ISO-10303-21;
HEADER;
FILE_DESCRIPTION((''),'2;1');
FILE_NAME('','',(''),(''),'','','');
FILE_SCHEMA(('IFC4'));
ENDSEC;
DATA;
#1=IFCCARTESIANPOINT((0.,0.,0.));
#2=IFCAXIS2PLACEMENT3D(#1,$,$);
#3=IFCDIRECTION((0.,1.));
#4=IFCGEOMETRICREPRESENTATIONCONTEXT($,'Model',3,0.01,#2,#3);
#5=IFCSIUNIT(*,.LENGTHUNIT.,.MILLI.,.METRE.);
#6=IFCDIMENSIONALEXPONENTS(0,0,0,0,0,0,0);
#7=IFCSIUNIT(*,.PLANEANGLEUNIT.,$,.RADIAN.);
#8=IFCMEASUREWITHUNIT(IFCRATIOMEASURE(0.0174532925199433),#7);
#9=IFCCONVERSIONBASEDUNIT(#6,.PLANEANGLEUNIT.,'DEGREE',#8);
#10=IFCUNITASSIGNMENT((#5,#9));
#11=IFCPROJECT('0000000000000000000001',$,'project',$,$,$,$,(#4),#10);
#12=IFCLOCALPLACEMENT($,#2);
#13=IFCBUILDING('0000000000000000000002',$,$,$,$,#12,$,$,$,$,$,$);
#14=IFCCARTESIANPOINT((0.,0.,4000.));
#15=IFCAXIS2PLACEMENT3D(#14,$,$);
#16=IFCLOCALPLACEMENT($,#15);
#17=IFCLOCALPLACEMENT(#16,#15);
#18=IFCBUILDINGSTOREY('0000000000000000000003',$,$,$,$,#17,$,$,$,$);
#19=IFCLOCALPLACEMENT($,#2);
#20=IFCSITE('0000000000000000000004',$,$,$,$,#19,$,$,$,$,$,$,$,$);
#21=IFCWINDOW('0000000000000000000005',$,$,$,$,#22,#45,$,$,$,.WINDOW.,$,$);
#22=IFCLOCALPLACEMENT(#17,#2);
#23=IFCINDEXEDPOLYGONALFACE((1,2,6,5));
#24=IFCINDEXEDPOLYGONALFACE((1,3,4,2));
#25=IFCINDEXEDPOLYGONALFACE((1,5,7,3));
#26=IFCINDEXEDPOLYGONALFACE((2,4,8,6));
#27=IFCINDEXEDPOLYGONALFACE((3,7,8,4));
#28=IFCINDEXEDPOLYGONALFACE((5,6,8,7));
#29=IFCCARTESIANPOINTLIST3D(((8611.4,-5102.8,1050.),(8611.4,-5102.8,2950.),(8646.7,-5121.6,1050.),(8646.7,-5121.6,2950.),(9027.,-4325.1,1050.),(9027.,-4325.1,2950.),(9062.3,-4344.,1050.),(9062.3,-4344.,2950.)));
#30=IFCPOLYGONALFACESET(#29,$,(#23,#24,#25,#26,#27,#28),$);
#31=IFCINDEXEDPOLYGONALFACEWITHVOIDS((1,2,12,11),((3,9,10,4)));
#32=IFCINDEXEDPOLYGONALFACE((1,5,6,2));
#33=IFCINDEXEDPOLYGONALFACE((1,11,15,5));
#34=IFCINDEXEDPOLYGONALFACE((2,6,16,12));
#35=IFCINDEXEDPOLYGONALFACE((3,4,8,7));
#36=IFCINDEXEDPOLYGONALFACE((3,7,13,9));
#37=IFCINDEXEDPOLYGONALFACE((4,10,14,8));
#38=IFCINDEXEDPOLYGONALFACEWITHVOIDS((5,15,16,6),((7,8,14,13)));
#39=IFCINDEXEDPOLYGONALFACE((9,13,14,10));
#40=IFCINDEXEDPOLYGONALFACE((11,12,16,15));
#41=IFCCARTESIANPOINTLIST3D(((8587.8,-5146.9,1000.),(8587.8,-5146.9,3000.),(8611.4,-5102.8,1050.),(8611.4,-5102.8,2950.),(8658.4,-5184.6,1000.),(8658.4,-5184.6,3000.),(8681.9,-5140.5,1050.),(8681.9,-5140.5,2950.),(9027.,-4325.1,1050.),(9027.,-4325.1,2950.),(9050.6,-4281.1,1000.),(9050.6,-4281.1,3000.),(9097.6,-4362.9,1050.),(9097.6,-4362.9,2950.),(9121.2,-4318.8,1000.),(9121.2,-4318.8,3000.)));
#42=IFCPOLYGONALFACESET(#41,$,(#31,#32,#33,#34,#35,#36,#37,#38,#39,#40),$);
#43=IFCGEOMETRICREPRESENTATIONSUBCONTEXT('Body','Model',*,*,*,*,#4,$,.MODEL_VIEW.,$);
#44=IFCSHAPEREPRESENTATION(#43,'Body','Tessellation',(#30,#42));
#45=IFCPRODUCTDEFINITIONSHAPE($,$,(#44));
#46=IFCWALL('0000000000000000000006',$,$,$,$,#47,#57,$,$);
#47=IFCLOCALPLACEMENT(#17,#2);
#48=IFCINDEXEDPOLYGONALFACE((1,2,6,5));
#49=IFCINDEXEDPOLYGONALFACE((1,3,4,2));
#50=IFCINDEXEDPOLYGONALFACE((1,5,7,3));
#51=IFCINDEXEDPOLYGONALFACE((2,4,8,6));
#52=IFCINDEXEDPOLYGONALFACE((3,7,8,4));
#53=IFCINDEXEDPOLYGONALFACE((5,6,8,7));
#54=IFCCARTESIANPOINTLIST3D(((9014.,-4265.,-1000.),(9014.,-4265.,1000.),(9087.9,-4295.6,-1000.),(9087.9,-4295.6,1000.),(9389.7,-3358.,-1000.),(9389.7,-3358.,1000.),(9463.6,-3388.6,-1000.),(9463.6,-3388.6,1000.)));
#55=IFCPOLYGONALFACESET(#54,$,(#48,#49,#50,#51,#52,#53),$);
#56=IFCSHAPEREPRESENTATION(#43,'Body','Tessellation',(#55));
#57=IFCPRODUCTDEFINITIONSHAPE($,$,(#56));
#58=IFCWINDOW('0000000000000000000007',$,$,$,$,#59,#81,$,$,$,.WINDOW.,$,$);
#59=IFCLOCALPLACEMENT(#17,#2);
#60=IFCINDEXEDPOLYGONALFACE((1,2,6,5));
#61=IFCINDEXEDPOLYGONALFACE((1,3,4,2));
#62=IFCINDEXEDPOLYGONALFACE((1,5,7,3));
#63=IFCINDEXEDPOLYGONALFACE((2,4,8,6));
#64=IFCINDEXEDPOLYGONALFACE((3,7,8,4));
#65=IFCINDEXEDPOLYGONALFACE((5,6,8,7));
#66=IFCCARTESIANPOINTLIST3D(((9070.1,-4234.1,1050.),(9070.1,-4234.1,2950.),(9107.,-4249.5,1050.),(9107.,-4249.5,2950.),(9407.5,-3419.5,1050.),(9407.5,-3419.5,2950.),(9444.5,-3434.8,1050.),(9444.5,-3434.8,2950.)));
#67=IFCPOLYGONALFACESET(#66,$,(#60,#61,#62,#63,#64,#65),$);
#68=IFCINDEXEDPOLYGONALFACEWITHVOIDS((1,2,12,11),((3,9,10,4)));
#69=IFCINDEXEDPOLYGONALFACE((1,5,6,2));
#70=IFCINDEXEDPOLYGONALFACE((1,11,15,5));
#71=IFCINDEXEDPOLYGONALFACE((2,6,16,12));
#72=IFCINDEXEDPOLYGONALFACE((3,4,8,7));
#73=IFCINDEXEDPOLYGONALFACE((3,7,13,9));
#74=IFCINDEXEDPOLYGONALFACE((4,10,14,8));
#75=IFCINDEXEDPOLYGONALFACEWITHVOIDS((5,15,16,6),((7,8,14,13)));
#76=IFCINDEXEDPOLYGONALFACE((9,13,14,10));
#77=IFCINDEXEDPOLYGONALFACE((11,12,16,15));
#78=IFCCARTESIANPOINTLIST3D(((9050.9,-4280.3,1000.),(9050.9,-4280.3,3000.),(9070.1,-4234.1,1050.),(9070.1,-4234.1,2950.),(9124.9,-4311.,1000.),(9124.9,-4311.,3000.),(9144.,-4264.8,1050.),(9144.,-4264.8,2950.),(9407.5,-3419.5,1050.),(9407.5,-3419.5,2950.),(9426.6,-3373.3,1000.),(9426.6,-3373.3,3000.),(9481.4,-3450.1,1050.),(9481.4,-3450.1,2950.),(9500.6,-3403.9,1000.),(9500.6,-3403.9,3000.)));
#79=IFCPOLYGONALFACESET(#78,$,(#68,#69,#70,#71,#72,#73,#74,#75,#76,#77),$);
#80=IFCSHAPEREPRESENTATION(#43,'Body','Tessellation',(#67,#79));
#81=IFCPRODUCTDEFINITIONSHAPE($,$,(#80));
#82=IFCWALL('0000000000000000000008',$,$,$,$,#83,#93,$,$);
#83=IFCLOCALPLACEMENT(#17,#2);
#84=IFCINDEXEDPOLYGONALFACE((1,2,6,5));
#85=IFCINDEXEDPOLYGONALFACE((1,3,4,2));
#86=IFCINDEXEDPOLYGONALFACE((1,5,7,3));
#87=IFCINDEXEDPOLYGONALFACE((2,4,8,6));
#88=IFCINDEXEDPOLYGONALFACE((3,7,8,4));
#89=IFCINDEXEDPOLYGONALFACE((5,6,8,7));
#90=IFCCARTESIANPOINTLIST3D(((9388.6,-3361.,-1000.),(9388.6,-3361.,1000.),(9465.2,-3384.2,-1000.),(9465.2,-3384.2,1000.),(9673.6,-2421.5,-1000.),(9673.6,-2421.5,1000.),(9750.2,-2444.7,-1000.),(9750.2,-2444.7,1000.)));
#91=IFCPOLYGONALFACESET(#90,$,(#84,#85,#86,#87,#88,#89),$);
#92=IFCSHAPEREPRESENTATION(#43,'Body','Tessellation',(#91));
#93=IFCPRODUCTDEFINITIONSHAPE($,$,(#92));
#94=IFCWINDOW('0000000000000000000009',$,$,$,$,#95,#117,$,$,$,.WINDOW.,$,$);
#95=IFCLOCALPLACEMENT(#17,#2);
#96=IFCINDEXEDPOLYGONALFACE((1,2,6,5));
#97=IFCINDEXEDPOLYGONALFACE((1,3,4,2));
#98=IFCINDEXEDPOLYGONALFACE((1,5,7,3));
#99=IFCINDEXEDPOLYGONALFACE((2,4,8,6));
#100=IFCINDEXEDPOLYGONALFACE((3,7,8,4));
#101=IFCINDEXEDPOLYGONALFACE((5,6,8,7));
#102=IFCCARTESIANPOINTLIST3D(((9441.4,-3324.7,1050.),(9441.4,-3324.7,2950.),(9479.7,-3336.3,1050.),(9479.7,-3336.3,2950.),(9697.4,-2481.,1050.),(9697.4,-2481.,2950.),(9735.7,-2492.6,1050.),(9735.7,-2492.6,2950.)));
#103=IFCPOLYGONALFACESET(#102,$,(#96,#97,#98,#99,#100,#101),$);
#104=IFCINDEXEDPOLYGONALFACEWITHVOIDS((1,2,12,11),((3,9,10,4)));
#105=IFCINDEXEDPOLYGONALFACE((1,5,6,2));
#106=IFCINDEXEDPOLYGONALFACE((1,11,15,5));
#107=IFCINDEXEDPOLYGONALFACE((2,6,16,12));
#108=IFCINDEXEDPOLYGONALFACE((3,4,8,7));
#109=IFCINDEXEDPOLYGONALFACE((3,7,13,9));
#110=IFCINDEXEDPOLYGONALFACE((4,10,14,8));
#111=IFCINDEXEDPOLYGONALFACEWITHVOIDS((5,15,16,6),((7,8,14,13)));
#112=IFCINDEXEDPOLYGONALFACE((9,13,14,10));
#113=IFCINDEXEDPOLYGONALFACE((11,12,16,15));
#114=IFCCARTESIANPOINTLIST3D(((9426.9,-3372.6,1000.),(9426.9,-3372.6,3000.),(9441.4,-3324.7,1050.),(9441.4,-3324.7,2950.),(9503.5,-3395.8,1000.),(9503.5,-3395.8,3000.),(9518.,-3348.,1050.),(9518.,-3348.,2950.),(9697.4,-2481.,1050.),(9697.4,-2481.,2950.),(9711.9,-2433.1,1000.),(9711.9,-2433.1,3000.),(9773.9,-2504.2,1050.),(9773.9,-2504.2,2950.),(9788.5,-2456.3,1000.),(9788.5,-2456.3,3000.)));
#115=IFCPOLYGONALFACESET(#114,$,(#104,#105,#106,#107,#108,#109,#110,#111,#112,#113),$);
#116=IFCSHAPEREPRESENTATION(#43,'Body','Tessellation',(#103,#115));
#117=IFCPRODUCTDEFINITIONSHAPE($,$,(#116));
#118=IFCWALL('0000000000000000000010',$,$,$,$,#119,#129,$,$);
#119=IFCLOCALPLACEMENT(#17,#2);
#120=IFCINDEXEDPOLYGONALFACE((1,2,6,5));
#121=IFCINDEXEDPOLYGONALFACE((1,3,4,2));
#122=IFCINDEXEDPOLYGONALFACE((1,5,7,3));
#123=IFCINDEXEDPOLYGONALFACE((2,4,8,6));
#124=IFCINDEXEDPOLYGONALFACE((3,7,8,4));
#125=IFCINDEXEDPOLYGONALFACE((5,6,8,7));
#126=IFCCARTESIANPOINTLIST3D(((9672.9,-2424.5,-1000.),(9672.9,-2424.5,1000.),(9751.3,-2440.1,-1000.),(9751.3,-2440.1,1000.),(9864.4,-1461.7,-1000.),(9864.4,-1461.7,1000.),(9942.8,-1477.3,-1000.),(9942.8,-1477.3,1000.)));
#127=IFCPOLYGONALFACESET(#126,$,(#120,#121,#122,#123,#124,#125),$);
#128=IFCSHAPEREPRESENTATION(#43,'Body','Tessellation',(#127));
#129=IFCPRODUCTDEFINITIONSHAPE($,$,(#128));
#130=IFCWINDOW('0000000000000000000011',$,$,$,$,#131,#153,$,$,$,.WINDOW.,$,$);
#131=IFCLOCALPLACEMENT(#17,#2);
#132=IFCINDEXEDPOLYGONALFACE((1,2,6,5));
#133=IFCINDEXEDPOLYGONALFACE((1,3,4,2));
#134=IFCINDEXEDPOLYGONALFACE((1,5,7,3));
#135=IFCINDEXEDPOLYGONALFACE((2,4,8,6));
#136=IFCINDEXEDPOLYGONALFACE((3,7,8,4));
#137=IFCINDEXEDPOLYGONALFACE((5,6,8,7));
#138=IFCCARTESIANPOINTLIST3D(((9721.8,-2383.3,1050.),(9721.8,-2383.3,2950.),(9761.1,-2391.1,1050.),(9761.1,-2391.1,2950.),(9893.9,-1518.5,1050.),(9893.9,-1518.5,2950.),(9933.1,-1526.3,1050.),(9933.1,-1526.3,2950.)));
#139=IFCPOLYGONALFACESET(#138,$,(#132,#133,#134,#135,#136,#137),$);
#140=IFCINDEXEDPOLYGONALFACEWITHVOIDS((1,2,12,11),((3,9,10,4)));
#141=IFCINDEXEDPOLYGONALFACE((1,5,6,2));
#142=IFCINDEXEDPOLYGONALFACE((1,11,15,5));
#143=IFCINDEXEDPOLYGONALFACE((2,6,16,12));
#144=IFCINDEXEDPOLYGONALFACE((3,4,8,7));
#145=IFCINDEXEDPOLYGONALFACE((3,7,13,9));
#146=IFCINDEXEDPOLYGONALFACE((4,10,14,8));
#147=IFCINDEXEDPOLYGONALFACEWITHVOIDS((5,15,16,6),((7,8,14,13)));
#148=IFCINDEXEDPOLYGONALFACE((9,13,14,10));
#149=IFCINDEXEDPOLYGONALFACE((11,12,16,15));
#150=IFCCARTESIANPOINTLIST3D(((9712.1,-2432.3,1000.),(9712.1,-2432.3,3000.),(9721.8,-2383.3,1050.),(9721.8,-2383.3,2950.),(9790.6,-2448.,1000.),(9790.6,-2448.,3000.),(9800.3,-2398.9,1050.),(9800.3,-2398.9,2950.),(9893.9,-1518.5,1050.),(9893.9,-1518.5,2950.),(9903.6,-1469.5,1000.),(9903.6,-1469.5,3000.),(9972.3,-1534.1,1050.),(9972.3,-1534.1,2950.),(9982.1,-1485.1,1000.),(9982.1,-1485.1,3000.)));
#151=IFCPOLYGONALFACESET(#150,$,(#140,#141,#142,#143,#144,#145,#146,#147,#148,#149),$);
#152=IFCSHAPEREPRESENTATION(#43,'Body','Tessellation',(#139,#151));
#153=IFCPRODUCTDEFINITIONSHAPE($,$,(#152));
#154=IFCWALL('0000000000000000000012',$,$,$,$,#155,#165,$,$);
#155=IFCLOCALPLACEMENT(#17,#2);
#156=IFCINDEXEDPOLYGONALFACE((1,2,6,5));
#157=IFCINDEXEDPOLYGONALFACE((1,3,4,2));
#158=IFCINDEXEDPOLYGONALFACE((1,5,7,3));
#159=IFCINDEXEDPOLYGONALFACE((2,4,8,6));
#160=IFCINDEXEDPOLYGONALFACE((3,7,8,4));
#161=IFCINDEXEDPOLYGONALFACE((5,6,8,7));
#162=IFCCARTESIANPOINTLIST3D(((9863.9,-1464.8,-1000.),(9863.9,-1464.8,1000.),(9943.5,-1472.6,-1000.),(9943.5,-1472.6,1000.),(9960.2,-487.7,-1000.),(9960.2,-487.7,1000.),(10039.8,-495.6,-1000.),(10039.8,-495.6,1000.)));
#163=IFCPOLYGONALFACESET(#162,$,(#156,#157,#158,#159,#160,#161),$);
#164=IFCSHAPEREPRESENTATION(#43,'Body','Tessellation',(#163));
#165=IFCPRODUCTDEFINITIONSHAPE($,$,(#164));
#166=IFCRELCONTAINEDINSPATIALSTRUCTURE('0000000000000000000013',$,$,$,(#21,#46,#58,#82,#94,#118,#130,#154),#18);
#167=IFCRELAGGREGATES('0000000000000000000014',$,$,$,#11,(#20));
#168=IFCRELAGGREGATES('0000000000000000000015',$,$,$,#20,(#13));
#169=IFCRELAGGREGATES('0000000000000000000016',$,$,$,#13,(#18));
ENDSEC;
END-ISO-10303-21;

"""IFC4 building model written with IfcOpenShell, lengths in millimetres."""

from ifc_helpers import new_model, entity, si_unit, converted_unit, direction, frame, origin, origin_2d, place, context, subcontext, project, spatial, rectangle, extrude, element, save


model = new_model("IFC4")

# Units and contexts
model_context = context("Model", 3, precision=0.01, world=origin(), true_north=direction((0.0, 1.0)))
body_context = subcontext(model_context, "Body", "Model", "MODEL_VIEW")
ifc_project = project(units=[si_unit("LENGTHUNIT", "METRE", prefix="MILLI"), converted_unit("PLANEANGLEUNIT", "DEGREE", entity("IfcRatioMeasure", 0.0174532925199433), si_unit("PLANEANGLEUNIT", "RADIAN"), dimensions=[0, 0, 0, 0, 0, 0, 0])], contexts=[model_context])

# Site, building, storey
site_placement = place(None, origin())
site = spatial("IfcSite", under=ifc_project, at=site_placement)
building_placement = place(None, origin())
building = spatial("IfcBuilding", under=site, at=building_placement)
placement = place(None, frame((0.0, 0.0, 4000.0)))
storey_placement = place(placement, frame((0.0, 0.0, 4000.0)))
storey = spatial("IfcBuildingStorey", under=building, at=storey_placement)

# Shared definitions
cartesian_point_1 = entity("IfcCartesianPoint", [-440.9, -950.0])
shared_polyline = entity("IfcPolyline", [cartesian_point_1, entity("IfcCartesianPoint", [-440.9, 950.0]), entity("IfcCartesianPoint", [-440.9, 950.0]), entity("IfcCartesianPoint", [440.9, 950.0]), entity("IfcCartesianPoint", [440.9, 950.0]), entity("IfcCartesianPoint", [440.9, -950.0]), entity("IfcCartesianPoint", [440.9, -950.0]), entity("IfcCartesianPoint", [-440.9, -950.0]), cartesian_point_1])

# Window
window_1_placement = place(storey_placement, frame((8819.2, -4714.0, 2000.0), z_axis=(0.0, 0.0, 1.0), x_axis=(4713.965487, 8819.213649, 0.0)))
cartesian_point_2 = entity("IfcCartesianPoint", [-490.9, -1000.0])
element("IfcWindow", 1, at=window_1_placement, inside=storey, PredefinedType="WINDOW", context=body_context, shape_type="SweptSolid", body=[
    entity("IfcExtrudedAreaSolid", entity("IfcArbitraryClosedProfileDef", "AREA", None, shared_polyline), entity("IfcAxis2Placement3D", entity("IfcCartesianPoint", [0.0, 0.0, 0.0]), entity("IfcDirection", [0.0, -1.0, 0.0]), entity("IfcDirection", [1.0, 0.0, 0.0])), entity("IfcDirection", [0.0, 0.0, 1.0]), 40.0),
    entity("IfcExtrudedAreaSolid", entity("IfcArbitraryProfileDefWithVoids", "AREA", None, entity("IfcPolyline", [cartesian_point_2, entity("IfcCartesianPoint", [-490.9, 1000.0]), entity("IfcCartesianPoint", [-490.9, 1000.0]), entity("IfcCartesianPoint", [490.9, 1000.0]), entity("IfcCartesianPoint", [490.9, 1000.0]), entity("IfcCartesianPoint", [490.9, -1000.0]), entity("IfcCartesianPoint", [490.9, -1000.0]), entity("IfcCartesianPoint", [-490.9, -1000.0]), cartesian_point_2]), [shared_polyline]), entity("IfcAxis2Placement3D", entity("IfcCartesianPoint", [0.0, 0.0, 0.0]), entity("IfcDirection", [0.0, -1.0, 0.0]), entity("IfcDirection", [1.0, 0.0, 0.0])), entity("IfcDirection", [0.0, 0.0, 1.0]), 80.0),
])

# Wall
wall_1_placement = place(storey_placement, frame((9238.8, -3826.8, -1000.0), z_axis=(0.0, 0.0, 1.0), x_axis=(3826.834186, 9238.795382, 0.0)))
element("IfcWall", 2, at=wall_1_placement, inside=storey, context=body_context, shape_type="SweptSolid", body=[
    extrude(rectangle(XDim=981.7, YDim=80.0, at=origin_2d()), origin(), (0.0, 0.0, 1.0), 2000.0),
])

# Window
window_2_placement = place(storey_placement, frame((9238.8, -3826.8, 2000.0), z_axis=(0.0, 0.0, 1.0), x_axis=(3826.834186, 9238.795382, 0.0)))
cartesian_point_3 = entity("IfcCartesianPoint", [-490.9, -1000.0])
element("IfcWindow", 3, at=window_2_placement, inside=storey, PredefinedType="WINDOW", context=body_context, shape_type="SweptSolid", body=[
    entity("IfcExtrudedAreaSolid", entity("IfcArbitraryClosedProfileDef", "AREA", None, shared_polyline), entity("IfcAxis2Placement3D", entity("IfcCartesianPoint", [0.0, 0.0, 0.0]), entity("IfcDirection", [0.0, -1.0, 0.0]), entity("IfcDirection", [1.0, 0.0, 0.0])), entity("IfcDirection", [0.0, 0.0, 1.0]), 40.0),
    entity("IfcExtrudedAreaSolid", entity("IfcArbitraryProfileDefWithVoids", "AREA", None, entity("IfcPolyline", [cartesian_point_3, entity("IfcCartesianPoint", [-490.9, 1000.0]), entity("IfcCartesianPoint", [-490.9, 1000.0]), entity("IfcCartesianPoint", [490.9, 1000.0]), entity("IfcCartesianPoint", [490.9, 1000.0]), entity("IfcCartesianPoint", [490.9, -1000.0]), entity("IfcCartesianPoint", [490.9, -1000.0]), entity("IfcCartesianPoint", [-490.9, -1000.0]), cartesian_point_3]), [shared_polyline]), entity("IfcAxis2Placement3D", entity("IfcCartesianPoint", [0.0, 0.0, 0.0]), entity("IfcDirection", [0.0, -1.0, 0.0]), entity("IfcDirection", [1.0, 0.0, 0.0])), entity("IfcDirection", [0.0, 0.0, 1.0]), 80.0),
])

# Wall
wall_2_placement = place(storey_placement, frame((9569.4, -2902.8, -1000.0), z_axis=(0.0, 0.0, 1.0), x_axis=(2902.848529, 9569.402825, 0.0)))
element("IfcWall", 4, at=wall_2_placement, inside=storey, context=body_context, shape_type="SweptSolid", body=[
    extrude(rectangle(XDim=981.7, YDim=80.0, at=origin_2d()), origin(), (0.0, 0.0, 1.0), 2000.0),
])

# Window
window_3_placement = place(storey_placement, frame((9569.4, -2902.8, 2000.0), z_axis=(0.0, 0.0, 1.0), x_axis=(2902.848529, 9569.402825, 0.0)))
cartesian_point_4 = entity("IfcCartesianPoint", [-490.9, -1000.0])
element("IfcWindow", 5, at=window_3_placement, inside=storey, PredefinedType="WINDOW", context=body_context, shape_type="SweptSolid", body=[
    entity("IfcExtrudedAreaSolid", entity("IfcArbitraryClosedProfileDef", "AREA", None, shared_polyline), entity("IfcAxis2Placement3D", entity("IfcCartesianPoint", [0.0, 0.0, 0.0]), entity("IfcDirection", [0.0, -1.0, 0.0]), entity("IfcDirection", [1.0, 0.0, 0.0])), entity("IfcDirection", [0.0, 0.0, 1.0]), 40.0),
    entity("IfcExtrudedAreaSolid", entity("IfcArbitraryProfileDefWithVoids", "AREA", None, entity("IfcPolyline", [cartesian_point_4, entity("IfcCartesianPoint", [-490.9, 1000.0]), entity("IfcCartesianPoint", [-490.9, 1000.0]), entity("IfcCartesianPoint", [490.9, 1000.0]), entity("IfcCartesianPoint", [490.9, 1000.0]), entity("IfcCartesianPoint", [490.9, -1000.0]), entity("IfcCartesianPoint", [490.9, -1000.0]), entity("IfcCartesianPoint", [-490.9, -1000.0]), cartesian_point_4]), [shared_polyline]), entity("IfcAxis2Placement3D", entity("IfcCartesianPoint", [0.0, 0.0, 0.0]), entity("IfcDirection", [0.0, -1.0, 0.0]), entity("IfcDirection", [1.0, 0.0, 0.0])), entity("IfcDirection", [0.0, 0.0, 1.0]), 80.0),
])

# Wall
wall_3_placement = place(storey_placement, frame((9807.9, -1950.9, -1000.0), z_axis=(0.0, 0.0, 1.0), x_axis=(1950.90229, 9807.852989, 0.0)))
element("IfcWall", 6, at=wall_3_placement, inside=storey, context=body_context, shape_type="SweptSolid", body=[
    extrude(rectangle(XDim=981.7, YDim=80.0, at=origin_2d()), origin(), (0.0, 0.0, 1.0), 2000.0),
])

# Window
window_4_placement = place(storey_placement, frame((9807.9, -1950.9, 2000.0), z_axis=(0.0, 0.0, 1.0), x_axis=(1950.90229, 9807.852989, 0.0)))
cartesian_point_5 = entity("IfcCartesianPoint", [-490.9, -1000.0])
element("IfcWindow", 7, at=window_4_placement, inside=storey, PredefinedType="WINDOW", context=body_context, shape_type="SweptSolid", body=[
    entity("IfcExtrudedAreaSolid", entity("IfcArbitraryClosedProfileDef", "AREA", None, shared_polyline), entity("IfcAxis2Placement3D", entity("IfcCartesianPoint", [0.0, 0.0, 0.0]), entity("IfcDirection", [0.0, -1.0, 0.0]), entity("IfcDirection", [1.0, 0.0, 0.0])), entity("IfcDirection", [0.0, 0.0, 1.0]), 40.0),
    entity("IfcExtrudedAreaSolid", entity("IfcArbitraryProfileDefWithVoids", "AREA", None, entity("IfcPolyline", [cartesian_point_5, entity("IfcCartesianPoint", [-490.9, 1000.0]), entity("IfcCartesianPoint", [-490.9, 1000.0]), entity("IfcCartesianPoint", [490.9, 1000.0]), entity("IfcCartesianPoint", [490.9, 1000.0]), entity("IfcCartesianPoint", [490.9, -1000.0]), entity("IfcCartesianPoint", [490.9, -1000.0]), entity("IfcCartesianPoint", [-490.9, -1000.0]), cartesian_point_5]), [shared_polyline]), entity("IfcAxis2Placement3D", entity("IfcCartesianPoint", [0.0, 0.0, 0.0]), entity("IfcDirection", [0.0, -1.0, 0.0]), entity("IfcDirection", [1.0, 0.0, 0.0])), entity("IfcDirection", [0.0, 0.0, 1.0]), 80.0),
])

# Wall
wall_4_placement = place(storey_placement, frame((9951.8, -980.2, -1000.0), z_axis=(0.0, 0.0, 1.0), x_axis=(980.172434, 9951.847165, 0.0)))
element("IfcWall", 8, at=wall_4_placement, inside=storey, context=body_context, shape_type="SweptSolid", body=[
    extrude(rectangle(XDim=981.7, YDim=80.0, at=origin_2d()), origin(), (0.0, 0.0, 1.0), 2000.0),
])

save(model, "model.ifc")
